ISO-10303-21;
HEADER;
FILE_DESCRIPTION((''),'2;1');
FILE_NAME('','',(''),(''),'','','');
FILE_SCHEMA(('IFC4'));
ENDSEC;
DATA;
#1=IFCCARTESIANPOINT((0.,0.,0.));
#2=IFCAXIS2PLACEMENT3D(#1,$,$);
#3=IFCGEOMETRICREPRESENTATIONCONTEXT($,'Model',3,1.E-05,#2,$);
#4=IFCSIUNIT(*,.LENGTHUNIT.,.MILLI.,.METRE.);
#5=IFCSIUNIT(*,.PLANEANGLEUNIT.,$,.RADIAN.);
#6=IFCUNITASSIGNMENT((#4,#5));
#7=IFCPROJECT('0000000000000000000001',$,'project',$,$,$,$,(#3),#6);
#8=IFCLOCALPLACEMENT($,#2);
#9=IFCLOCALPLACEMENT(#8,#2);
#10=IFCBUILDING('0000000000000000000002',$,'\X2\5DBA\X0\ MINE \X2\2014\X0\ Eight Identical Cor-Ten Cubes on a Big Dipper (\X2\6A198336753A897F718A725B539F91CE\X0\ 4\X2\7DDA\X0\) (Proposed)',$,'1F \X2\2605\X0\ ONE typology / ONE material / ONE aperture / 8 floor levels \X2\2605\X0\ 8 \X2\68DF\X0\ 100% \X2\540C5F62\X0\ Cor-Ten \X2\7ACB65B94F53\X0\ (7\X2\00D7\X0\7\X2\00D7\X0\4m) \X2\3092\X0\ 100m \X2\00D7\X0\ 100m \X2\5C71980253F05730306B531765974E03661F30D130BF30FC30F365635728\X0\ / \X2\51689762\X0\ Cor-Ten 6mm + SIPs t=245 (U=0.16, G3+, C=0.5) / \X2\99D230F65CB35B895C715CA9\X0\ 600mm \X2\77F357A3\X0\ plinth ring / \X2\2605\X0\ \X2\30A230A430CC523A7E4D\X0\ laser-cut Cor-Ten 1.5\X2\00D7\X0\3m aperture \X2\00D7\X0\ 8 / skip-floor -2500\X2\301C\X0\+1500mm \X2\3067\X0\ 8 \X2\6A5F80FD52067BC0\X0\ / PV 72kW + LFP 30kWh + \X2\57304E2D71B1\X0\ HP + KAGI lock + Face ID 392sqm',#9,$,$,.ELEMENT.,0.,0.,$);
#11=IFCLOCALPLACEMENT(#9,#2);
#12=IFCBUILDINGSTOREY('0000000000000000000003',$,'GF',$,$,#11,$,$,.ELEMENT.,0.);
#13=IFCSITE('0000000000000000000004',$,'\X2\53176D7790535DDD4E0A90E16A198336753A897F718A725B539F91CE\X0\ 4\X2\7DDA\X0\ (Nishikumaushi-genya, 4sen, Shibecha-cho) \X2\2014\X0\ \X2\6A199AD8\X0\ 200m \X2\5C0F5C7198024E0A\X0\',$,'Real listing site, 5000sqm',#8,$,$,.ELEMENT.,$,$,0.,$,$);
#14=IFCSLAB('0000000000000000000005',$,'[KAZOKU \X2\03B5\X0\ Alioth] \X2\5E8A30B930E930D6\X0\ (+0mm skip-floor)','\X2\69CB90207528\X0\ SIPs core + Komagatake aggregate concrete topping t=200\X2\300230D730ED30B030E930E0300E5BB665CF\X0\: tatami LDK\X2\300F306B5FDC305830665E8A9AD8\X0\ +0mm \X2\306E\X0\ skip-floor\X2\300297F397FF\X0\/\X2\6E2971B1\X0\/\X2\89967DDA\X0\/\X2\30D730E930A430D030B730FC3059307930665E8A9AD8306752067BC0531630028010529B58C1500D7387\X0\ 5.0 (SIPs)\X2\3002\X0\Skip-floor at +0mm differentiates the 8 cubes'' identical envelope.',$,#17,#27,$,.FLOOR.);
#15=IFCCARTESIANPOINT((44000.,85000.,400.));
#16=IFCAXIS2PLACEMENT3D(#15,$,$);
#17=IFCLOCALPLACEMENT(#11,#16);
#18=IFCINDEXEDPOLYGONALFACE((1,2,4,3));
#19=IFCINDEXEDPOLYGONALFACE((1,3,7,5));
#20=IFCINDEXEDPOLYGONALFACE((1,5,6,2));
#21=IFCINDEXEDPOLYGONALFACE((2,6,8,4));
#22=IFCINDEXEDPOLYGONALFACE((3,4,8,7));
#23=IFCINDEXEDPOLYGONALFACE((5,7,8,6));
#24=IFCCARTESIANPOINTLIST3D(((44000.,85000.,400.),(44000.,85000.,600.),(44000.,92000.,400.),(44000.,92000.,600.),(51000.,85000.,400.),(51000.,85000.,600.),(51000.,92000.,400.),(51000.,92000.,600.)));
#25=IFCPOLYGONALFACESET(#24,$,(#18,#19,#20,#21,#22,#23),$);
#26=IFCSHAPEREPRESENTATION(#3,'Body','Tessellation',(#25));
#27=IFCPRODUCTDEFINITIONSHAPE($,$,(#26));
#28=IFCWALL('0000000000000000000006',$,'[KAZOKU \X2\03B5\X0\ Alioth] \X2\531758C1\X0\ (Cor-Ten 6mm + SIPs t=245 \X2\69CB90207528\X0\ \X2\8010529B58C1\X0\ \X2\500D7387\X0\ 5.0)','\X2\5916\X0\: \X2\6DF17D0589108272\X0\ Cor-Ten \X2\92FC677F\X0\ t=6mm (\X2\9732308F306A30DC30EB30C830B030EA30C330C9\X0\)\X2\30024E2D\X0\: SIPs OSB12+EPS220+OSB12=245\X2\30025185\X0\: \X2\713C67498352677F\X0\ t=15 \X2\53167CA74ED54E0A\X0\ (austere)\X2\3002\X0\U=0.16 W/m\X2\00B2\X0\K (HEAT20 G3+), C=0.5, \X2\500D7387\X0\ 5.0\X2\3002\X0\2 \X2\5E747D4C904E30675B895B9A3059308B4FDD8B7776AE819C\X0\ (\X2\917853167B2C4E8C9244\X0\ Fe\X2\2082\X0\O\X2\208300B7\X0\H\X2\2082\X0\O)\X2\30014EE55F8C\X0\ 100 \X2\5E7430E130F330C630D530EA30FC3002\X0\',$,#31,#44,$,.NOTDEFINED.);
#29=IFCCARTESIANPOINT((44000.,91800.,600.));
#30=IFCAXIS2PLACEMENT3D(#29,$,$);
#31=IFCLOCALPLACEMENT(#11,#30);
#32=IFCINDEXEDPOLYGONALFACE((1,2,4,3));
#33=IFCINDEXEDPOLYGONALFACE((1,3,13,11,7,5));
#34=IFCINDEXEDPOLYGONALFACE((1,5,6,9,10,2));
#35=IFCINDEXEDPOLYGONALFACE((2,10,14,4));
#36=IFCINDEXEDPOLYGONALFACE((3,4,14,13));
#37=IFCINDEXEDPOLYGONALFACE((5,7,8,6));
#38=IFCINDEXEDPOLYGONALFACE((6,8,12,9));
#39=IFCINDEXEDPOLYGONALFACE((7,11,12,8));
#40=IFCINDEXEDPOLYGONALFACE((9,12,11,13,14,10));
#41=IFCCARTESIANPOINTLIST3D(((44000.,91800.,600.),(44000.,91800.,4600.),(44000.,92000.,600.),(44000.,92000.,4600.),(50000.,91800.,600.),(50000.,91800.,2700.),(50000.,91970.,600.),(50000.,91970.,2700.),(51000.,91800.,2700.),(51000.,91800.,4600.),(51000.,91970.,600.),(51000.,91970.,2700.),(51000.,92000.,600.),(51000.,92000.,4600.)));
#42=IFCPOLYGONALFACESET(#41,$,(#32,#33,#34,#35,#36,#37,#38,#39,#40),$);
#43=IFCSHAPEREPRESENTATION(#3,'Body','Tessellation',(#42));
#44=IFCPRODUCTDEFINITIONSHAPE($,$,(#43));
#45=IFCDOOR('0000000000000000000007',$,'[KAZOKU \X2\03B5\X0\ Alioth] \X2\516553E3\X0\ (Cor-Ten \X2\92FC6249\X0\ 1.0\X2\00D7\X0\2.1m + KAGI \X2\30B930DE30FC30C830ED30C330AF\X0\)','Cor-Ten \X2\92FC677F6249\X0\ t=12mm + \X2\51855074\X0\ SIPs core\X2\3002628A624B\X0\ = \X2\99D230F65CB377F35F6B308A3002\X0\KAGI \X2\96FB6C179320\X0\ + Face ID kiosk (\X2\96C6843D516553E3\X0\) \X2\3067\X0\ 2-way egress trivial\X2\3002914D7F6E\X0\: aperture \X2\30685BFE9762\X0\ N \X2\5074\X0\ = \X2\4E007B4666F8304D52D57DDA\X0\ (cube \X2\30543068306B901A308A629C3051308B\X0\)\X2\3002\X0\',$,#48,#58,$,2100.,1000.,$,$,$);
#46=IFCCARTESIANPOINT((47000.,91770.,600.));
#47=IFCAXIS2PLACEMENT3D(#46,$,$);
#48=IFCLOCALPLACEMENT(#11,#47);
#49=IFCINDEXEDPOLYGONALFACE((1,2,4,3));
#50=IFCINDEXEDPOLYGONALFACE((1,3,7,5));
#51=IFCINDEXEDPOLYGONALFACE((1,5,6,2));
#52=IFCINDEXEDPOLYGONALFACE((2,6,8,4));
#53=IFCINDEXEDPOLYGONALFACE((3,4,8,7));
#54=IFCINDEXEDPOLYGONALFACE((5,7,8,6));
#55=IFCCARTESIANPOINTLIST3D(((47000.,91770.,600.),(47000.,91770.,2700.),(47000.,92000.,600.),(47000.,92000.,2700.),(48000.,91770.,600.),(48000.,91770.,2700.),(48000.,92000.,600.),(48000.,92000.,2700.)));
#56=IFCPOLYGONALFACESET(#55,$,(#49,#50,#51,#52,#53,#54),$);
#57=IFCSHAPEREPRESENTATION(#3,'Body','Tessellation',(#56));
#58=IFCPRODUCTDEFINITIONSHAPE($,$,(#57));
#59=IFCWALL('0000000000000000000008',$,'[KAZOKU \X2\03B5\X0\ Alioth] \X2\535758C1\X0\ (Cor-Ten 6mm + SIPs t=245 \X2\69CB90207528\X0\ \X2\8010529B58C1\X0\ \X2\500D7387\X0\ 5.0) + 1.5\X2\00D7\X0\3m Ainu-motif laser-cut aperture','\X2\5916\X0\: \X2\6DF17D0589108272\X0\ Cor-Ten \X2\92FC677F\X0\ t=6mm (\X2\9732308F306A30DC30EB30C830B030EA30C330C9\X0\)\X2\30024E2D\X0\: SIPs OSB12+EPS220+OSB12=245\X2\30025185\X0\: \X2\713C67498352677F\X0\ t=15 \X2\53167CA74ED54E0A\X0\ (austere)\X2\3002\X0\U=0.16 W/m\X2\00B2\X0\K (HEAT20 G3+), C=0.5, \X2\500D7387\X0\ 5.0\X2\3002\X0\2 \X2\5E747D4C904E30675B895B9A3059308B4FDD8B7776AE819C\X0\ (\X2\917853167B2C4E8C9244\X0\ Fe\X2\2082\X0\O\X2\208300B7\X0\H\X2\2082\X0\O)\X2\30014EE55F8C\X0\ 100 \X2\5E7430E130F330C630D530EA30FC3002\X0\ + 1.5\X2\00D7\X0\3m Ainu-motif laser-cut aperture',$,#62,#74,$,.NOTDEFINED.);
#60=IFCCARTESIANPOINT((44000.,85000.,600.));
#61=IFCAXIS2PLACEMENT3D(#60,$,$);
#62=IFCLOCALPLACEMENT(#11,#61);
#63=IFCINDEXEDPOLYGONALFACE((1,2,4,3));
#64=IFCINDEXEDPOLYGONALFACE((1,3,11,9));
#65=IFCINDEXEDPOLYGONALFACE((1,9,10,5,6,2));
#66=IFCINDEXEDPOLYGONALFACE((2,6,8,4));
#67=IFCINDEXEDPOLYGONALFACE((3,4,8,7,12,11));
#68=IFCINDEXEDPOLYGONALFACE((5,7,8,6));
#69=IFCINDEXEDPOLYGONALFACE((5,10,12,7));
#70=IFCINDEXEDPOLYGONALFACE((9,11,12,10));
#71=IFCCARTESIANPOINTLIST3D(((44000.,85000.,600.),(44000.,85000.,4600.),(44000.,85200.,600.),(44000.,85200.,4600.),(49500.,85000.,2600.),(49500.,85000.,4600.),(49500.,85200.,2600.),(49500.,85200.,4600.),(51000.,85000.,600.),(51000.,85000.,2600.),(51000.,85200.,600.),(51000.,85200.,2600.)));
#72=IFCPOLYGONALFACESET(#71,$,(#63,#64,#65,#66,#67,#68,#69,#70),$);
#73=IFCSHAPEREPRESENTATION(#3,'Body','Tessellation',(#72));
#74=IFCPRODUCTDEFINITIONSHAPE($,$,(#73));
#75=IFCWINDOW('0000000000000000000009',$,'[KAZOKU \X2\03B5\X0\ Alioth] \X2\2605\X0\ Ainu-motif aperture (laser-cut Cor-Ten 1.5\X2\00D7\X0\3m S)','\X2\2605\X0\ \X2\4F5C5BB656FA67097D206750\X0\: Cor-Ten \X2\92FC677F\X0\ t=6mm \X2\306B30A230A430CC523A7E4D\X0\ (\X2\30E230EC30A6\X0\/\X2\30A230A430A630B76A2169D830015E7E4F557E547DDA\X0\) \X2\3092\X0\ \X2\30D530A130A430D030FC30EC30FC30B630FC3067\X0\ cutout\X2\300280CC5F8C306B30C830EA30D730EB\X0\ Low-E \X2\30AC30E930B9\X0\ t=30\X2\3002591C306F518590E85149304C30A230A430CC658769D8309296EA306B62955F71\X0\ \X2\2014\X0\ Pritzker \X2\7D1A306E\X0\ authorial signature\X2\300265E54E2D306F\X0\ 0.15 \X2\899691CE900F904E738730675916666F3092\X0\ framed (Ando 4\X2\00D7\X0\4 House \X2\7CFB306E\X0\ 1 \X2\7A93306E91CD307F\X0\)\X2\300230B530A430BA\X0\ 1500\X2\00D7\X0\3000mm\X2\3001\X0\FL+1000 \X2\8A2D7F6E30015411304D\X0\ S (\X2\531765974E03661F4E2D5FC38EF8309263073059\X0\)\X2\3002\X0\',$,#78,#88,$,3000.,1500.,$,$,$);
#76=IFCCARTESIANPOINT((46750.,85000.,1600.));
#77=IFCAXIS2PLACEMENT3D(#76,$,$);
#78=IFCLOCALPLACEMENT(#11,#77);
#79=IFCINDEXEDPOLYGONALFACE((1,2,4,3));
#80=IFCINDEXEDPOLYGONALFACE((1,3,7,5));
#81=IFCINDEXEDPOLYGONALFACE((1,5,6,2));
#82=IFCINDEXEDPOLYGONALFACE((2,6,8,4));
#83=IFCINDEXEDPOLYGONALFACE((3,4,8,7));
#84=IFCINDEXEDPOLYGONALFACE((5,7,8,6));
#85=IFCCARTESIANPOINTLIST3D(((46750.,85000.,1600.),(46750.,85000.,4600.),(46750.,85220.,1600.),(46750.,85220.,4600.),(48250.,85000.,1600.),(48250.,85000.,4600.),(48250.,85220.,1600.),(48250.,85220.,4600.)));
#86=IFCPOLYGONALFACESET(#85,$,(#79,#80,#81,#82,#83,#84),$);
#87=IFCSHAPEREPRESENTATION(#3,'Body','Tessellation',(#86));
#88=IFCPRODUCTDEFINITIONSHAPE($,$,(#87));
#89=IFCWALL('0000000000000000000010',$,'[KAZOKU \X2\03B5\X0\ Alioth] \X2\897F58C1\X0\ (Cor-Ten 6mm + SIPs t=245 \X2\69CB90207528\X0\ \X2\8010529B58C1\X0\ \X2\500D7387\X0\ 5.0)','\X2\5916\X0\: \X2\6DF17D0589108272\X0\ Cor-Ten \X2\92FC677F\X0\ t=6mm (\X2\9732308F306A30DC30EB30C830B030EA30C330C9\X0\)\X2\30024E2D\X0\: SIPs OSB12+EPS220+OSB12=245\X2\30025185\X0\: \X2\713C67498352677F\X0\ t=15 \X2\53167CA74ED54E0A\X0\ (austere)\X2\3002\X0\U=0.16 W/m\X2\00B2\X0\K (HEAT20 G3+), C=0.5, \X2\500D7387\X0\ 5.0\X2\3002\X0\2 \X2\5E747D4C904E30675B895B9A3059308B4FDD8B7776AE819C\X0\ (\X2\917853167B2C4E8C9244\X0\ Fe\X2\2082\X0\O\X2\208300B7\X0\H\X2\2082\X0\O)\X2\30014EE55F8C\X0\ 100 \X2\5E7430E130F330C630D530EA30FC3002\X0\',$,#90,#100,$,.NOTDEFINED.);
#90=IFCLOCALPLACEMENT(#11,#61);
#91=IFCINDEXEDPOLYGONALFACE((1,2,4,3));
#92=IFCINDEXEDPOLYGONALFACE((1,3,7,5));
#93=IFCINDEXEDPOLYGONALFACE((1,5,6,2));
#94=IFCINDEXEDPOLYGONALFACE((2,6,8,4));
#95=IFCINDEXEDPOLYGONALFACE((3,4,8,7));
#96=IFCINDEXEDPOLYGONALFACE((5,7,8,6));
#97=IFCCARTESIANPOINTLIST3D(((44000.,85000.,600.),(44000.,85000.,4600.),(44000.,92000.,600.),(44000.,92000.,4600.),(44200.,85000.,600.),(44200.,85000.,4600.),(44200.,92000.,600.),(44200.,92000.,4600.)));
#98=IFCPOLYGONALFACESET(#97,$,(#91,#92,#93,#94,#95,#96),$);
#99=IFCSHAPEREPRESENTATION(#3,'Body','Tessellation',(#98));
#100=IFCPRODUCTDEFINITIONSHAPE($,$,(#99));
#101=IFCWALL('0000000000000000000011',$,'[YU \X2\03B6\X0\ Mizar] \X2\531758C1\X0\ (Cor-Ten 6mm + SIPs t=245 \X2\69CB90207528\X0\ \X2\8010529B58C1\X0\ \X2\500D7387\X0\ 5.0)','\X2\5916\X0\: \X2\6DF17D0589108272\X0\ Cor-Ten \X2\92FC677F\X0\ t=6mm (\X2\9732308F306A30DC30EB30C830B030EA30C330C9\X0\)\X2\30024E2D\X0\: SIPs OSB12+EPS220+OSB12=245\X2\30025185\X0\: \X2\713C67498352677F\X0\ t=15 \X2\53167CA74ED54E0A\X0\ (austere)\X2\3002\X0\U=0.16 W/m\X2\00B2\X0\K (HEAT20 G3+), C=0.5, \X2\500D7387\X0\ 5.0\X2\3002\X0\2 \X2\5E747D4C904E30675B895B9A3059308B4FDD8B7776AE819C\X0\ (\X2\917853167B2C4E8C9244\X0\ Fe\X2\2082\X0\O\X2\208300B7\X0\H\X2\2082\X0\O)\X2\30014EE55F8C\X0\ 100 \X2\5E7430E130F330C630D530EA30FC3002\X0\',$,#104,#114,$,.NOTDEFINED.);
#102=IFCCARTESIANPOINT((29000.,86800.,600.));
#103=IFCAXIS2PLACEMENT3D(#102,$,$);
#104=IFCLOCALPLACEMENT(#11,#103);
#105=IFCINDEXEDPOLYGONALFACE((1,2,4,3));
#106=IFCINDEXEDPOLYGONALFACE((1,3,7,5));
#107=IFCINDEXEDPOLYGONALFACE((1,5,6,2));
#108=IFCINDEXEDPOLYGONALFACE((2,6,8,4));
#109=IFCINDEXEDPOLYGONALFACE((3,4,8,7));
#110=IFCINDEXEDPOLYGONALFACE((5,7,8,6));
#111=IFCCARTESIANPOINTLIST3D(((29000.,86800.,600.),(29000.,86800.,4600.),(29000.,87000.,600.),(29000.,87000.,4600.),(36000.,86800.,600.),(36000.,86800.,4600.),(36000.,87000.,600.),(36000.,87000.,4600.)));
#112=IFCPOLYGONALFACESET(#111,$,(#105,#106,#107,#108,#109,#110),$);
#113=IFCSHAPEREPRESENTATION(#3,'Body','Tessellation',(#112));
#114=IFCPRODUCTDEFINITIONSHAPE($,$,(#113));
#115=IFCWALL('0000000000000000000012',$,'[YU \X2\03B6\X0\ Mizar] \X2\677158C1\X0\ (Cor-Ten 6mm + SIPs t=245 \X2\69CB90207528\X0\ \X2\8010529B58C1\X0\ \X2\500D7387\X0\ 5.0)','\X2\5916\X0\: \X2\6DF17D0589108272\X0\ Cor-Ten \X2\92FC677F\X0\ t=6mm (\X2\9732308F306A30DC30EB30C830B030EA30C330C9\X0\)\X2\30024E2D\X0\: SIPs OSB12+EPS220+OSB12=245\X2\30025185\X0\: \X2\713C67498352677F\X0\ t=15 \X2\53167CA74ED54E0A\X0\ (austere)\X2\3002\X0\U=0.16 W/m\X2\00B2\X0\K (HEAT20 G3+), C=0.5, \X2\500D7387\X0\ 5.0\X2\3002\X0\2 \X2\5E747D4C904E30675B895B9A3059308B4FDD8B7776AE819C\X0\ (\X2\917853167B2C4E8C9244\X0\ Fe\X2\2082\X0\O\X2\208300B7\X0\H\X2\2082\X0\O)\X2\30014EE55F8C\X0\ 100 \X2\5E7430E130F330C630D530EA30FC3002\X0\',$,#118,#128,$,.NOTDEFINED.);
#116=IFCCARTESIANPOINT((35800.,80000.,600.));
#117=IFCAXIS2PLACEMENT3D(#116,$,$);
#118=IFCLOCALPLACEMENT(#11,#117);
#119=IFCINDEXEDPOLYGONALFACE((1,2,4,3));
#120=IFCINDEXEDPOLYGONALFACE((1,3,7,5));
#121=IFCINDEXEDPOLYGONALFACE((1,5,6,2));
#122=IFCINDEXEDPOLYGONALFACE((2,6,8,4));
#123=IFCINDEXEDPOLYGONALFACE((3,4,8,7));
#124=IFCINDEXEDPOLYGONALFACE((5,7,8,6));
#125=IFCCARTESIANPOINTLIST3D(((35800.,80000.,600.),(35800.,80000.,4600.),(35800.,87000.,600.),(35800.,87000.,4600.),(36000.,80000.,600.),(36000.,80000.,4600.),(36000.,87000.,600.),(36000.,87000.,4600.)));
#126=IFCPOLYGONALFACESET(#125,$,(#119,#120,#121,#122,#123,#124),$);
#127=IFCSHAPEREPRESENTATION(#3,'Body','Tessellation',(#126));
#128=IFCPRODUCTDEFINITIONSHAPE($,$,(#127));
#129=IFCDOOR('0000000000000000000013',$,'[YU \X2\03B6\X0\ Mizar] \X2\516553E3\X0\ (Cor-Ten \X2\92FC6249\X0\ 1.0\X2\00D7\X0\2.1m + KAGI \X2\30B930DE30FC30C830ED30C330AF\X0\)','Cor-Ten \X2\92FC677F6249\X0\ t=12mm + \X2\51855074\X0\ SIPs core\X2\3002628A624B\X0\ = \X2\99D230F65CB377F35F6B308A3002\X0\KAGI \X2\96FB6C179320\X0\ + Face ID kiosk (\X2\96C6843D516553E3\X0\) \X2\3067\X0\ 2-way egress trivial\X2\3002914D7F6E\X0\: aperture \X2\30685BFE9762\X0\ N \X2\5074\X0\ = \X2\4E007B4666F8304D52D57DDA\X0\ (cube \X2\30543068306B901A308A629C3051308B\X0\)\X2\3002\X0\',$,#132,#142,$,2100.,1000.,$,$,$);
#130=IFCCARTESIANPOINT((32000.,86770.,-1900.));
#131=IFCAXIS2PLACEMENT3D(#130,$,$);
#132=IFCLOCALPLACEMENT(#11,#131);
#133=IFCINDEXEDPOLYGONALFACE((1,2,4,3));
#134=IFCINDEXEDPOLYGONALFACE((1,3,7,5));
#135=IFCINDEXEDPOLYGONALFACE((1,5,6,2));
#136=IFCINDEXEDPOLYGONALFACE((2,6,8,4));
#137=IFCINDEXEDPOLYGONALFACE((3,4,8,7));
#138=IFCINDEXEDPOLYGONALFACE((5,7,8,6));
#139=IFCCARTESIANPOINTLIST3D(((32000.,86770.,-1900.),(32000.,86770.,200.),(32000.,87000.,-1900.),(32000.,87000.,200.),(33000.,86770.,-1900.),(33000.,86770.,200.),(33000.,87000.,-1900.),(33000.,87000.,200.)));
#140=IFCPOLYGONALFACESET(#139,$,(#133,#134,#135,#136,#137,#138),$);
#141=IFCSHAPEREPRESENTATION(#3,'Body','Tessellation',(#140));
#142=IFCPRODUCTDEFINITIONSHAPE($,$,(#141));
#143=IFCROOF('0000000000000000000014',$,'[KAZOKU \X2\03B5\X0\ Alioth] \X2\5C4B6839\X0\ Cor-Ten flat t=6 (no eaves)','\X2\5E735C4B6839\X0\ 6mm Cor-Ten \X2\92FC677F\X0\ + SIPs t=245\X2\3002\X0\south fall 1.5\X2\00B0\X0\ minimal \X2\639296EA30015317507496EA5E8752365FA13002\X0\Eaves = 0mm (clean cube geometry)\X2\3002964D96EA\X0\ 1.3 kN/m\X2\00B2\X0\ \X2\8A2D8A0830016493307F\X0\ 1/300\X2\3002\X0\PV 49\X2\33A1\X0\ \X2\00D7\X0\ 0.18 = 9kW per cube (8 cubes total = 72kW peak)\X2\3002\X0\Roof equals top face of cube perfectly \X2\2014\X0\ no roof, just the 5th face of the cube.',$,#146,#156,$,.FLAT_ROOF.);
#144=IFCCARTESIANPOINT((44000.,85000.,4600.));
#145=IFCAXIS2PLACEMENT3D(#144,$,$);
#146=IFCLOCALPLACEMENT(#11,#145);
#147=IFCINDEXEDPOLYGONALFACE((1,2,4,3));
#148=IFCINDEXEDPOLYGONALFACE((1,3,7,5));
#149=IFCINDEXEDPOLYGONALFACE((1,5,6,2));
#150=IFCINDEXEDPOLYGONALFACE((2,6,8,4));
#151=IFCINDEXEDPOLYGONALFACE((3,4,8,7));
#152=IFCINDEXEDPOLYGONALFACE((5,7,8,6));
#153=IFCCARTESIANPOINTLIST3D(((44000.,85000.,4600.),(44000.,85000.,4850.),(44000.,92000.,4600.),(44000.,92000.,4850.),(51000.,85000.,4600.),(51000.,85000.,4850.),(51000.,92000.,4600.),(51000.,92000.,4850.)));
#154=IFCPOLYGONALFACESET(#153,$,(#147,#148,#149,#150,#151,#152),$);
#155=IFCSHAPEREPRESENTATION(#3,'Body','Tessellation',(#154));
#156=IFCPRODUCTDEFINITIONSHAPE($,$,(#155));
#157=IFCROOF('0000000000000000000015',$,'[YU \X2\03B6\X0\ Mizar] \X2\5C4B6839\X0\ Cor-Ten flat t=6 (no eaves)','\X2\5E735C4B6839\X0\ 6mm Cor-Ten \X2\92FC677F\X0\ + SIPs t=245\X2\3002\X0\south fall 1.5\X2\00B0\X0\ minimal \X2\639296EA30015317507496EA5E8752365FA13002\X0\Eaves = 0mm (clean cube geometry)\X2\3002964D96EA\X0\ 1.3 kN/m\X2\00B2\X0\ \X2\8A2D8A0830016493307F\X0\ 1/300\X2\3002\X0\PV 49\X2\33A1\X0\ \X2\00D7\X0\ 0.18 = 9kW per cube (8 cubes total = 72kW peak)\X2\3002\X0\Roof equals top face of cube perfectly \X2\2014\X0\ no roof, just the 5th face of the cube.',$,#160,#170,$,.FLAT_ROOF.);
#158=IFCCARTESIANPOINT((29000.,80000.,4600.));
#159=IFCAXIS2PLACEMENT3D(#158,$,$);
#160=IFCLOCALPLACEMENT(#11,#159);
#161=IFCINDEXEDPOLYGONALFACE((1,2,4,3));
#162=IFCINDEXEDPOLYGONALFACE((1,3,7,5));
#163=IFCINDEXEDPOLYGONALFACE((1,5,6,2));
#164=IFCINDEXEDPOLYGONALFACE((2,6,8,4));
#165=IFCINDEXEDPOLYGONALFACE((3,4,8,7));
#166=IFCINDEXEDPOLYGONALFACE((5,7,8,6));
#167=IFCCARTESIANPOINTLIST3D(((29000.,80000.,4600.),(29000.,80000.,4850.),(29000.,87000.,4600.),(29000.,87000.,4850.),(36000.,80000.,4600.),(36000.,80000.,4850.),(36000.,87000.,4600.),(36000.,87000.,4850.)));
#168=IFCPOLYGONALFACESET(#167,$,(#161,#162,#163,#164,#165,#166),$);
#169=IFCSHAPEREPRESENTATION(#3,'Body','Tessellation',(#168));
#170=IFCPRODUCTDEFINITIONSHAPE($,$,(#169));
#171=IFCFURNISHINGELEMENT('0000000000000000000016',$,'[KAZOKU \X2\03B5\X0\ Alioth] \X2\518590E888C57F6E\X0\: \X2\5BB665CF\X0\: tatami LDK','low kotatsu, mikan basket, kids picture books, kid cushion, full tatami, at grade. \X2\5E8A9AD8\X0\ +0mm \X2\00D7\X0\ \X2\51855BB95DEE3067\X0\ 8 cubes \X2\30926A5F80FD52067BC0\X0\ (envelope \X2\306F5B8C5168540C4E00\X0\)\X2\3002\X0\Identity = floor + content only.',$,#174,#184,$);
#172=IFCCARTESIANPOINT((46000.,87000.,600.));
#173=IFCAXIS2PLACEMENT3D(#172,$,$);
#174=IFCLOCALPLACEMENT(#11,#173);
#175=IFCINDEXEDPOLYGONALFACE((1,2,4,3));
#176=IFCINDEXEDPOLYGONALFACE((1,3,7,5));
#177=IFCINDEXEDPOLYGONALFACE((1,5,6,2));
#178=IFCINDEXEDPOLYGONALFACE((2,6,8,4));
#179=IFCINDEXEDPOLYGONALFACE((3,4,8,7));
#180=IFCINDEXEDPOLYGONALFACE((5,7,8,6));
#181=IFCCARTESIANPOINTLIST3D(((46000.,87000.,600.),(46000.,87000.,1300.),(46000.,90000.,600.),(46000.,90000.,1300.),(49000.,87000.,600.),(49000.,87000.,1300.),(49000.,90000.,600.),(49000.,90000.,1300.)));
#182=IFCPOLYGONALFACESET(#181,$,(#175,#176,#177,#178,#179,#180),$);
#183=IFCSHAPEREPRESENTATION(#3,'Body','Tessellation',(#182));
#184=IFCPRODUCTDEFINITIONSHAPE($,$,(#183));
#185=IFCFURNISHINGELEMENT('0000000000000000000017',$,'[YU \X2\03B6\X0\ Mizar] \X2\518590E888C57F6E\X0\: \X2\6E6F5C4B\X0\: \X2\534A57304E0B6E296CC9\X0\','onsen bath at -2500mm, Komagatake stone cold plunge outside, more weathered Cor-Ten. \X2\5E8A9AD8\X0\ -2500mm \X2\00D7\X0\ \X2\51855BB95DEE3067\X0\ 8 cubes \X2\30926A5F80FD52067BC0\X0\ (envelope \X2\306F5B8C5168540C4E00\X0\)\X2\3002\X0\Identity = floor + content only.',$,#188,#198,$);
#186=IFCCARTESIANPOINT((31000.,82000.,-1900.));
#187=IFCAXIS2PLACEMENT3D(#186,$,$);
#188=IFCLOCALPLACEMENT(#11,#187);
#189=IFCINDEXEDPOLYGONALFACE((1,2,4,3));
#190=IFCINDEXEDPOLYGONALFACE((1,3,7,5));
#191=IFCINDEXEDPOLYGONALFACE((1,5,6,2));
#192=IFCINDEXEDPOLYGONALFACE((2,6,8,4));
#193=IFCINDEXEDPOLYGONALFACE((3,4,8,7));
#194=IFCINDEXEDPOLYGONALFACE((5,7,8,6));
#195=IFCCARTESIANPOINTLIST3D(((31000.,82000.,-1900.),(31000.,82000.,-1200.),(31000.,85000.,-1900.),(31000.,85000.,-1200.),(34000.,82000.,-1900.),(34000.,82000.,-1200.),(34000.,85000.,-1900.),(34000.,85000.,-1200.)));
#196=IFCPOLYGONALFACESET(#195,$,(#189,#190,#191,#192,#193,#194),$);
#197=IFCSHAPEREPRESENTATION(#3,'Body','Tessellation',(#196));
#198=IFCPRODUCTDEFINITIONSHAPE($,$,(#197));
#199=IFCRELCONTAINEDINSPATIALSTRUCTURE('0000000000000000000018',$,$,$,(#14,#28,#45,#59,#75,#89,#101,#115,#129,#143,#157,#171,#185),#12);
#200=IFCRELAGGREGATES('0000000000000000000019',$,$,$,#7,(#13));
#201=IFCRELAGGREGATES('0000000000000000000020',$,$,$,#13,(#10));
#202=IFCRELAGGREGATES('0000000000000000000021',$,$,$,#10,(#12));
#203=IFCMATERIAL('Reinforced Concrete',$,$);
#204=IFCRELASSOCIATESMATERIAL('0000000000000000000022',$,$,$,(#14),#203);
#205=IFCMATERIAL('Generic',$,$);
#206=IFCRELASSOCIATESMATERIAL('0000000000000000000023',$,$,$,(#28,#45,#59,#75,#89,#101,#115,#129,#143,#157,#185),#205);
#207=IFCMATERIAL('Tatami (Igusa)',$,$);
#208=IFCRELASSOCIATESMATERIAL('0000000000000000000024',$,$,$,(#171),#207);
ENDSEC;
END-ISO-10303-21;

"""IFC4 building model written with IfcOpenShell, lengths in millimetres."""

from ifc_helpers import new_model, si_unit, frame, frame_2d, origin, place, context, project, spatial, rectangle, extrude, material, element, fill, save


model = new_model("IFC4")

# Units and contexts
model_context = context("Model", 3, precision=1e-05, world=origin())
ifc_project = project(units=[si_unit("LENGTHUNIT", "METRE", prefix="MILLI"), si_unit("PLANEANGLEUNIT", "RADIAN")], contexts=[model_context])

# Site, building, storey
site_placement = place(None, origin())
site = spatial("IfcSite", under=ifc_project, at=site_placement, Name="北海道川上郡標茶町西熊牛原野 4線 (Nishikumaushi-genya, 4sen, Shibecha-cho) — 標高 200m 小山頂上", ObjectType="Real listing site, 5000sqm", CompositionType="ELEMENT", RefElevation=0.0)
building_placement = place(site_placement, origin())
building = spatial("IfcBuilding", under=site, at=building_placement, Name="嶺 MINE — Eight Identical Cor-Ten Cubes on a Big Dipper (標茶町西熊牛原野 4線) (Proposed)", ObjectType="1F ★ ONE typology / ONE material / ONE aperture / 8 floor levels ★ 8 棟 100% 同形 Cor-Ten 立方体 (7×7×4m) を 100m × 100m 山頂台地に北斗七星パターン散在 / 全面 Cor-Ten 6mm + SIPs t=245 (U=0.16, G3+, C=0.5) / 駒ヶ岳安山岩 600mm 石垣 plinth ring / ★ アイヌ刺繍 laser-cut Cor-Ten 1.5×3m aperture × 8 / skip-floor -2500〜+1500mm で 8 機能分節 / PV 72kW + LFP 30kWh + 地中熱 HP + KAGI lock + Face ID 392sqm", CompositionType="ELEMENT", ElevationOfRefHeight=0.0, ElevationOfTerrain=0.0)
storey_placement = place(building_placement, origin())
storey = spatial("IfcBuildingStorey", under=building, at=storey_placement, Name="GF", CompositionType="ELEMENT", Elevation=0.0)

# Slab
ifc_material_1 = material(Name="Reinforced Concrete")
slab_placement = place(storey_placement, frame((44000.0, 85000.0, 400.0)))
element("IfcSlab", 1, at=slab_placement, inside=storey, material=ifc_material_1, Name="[KAZOKU ε Alioth] 床スラブ (+0mm skip-floor)", Description="構造用 SIPs core + Komagatake aggregate concrete topping t=200。プログラム『家族: tatami LDK』に応じて床高 +0mm の skip-floor。音響/温熱/視線/プライバシーすべて床高で分節化。耐力壁倍率 5.0 (SIPs)。Skip-floor at +0mm differentiates the 8 cubes' identical envelope.", PredefinedType="FLOOR", context=model_context, shape_type="SweptSolid", body=[
    extrude(rectangle(XDim=7000.0, YDim=7000.0, at=frame_2d((3500.0, 3500.0))), frame((44000.0, 85000.0, 400.0)), (0.0, 0.0, 1.0), 200.0),
])

# Wall, opening, door
ifc_material_2 = material(Name="Generic")
wall_1_placement = place(storey_placement, frame((44000.0, 91800.0, 600.0)))
wall_1 = element("IfcWall", 2, at=wall_1_placement, inside=storey, material=ifc_material_2, Name="[KAZOKU ε Alioth] 北壁 (Cor-Ten 6mm + SIPs t=245 構造用 耐力壁 倍率 5.0)", Description="外: 深紅褐色 Cor-Ten 鋼板 t=6mm (露わなボルトグリッド)。中: SIPs OSB12+EPS220+OSB12=245。内: 焼杉荒板 t=15 化粧仕上 (austere)。U=0.16 W/m²K (HEAT20 G3+), C=0.5, 倍率 5.0。2 年経過で安定する保護皮膜 (酸化第二鉄 Fe₂O₃·H₂O)、以後 100 年メンテフリー。", PredefinedType="NOTDEFINED", context=model_context, shape_type="SweptSolid", body=[
    extrude(rectangle(XDim=7000.0, YDim=200.0, at=frame_2d((3500.0, 100.0))), frame((44000.0, 91800.0, 600.0)), (0.0, 0.0, 1.0), 4000.0),
])
opening_1_placement = place(storey_placement, frame((47000.0, 91770.0, 600.0)))
opening_1 = element("IfcOpeningElement", 3, at=opening_1_placement, cuts=wall_1, PredefinedType="NOTDEFINED", context=model_context, shape_type="SweptSolid", body=[
    extrude(rectangle(XDim=1000.0, YDim=230.0, at=frame_2d((500.0, 115.0))), frame((47000.0, 91770.0, 600.0)), (0.0, 0.0, 1.0), 2100.0),
])
door_1_placement = place(storey_placement, frame((47000.0, 91770.0, 600.0)))
door_1 = element("IfcDoor", 4, at=door_1_placement, inside=storey, material=ifc_material_2, Name="[KAZOKU ε Alioth] 入口 (Cor-Ten 鋼扉 1.0×2.1m + KAGI スマートロック)", Description="Cor-Ten 鋼板扉 t=12mm + 内側 SIPs core。把手 = 駒ヶ岳石彫り。KAGI 電気錠 + Face ID kiosk (集落入口) で 2-way egress trivial。配置: aperture と対面 N 側 = 一筆書き動線 (cube ごとに通り抜ける)。", OverallHeight=2100.0, OverallWidth=1000.0, context=model_context, shape_type="SweptSolid", body=[
    extrude(rectangle(XDim=1000.0, YDim=230.0, at=frame_2d((500.0, 115.0))), frame((47000.0, 91770.0, 600.0)), (0.0, 0.0, 1.0), 2100.0),
])
fill(opening_1, door_1)

# Wall, opening, window
wall_2_placement = place(storey_placement, frame((44000.0, 85000.0, 600.0)))
wall_2 = element("IfcWall", 5, at=wall_2_placement, inside=storey, material=ifc_material_2, Name="[KAZOKU ε Alioth] 南壁 (Cor-Ten 6mm + SIPs t=245 構造用 耐力壁 倍率 5.0) + 1.5×3m Ainu-motif laser-cut aperture", Description="外: 深紅褐色 Cor-Ten 鋼板 t=6mm (露わなボルトグリッド)。中: SIPs OSB12+EPS220+OSB12=245。内: 焼杉荒板 t=15 化粧仕上 (austere)。U=0.16 W/m²K (HEAT20 G3+), C=0.5, 倍率 5.0。2 年経過で安定する保護皮膜 (酸化第二鉄 Fe₂O₃·H₂O)、以後 100 年メンテフリー。 + 1.5×3m Ainu-motif laser-cut aperture", PredefinedType="NOTDEFINED", context=model_context, shape_type="SweptSolid", body=[
    extrude(rectangle(XDim=7000.0, YDim=200.0, at=frame_2d((3500.0, 100.0))), frame((44000.0, 85000.0, 600.0)), (0.0, 0.0, 1.0), 4000.0),
])
opening_2_placement = place(storey_placement, frame((46750.0, 85000.0, 1600.0)))
opening_2 = element("IfcOpeningElement", 6, at=opening_2_placement, cuts=wall_2, PredefinedType="NOTDEFINED", context=model_context, shape_type="SweptSolid", body=[
    extrude(rectangle(XDim=1500.0, YDim=220.0, at=frame_2d((750.0, 110.0))), frame((46750.0, 85000.0, 1600.0)), (0.0, 0.0, 1.0), 3000.0),
])
window_placement = place(storey_placement, frame((46750.0, 85000.0, 1600.0)))
window = element("IfcWindow", 7, at=window_placement, inside=storey, material=ifc_material_2, Name="[KAZOKU ε Alioth] ★ Ainu-motif aperture (laser-cut Cor-Ten 1.5×3m S)", Description="★ 作家固有素材: Cor-Ten 鋼板 t=6mm にアイヌ刺繍 (モレウ/アイウシ模様、幾何織線) を ファイバーレーザーで cutout。背後にトリプル Low-E ガラス t=30。夜は内部光がアイヌ文様を雪に投影 — Pritzker 級の authorial signature。日中は 0.15 視野透過率で外景を framed (Ando 4×4 House 系の 1 窓の重み)。サイズ 1500×3000mm、FL+1000 設置、向き S (北斗七星中心軸を指す)。", OverallHeight=3000.0, OverallWidth=1500.0, context=model_context, shape_type="SweptSolid", body=[
    extrude(rectangle(XDim=1500.0, YDim=220.0, at=frame_2d((750.0, 110.0))), frame((46750.0, 85000.0, 1600.0)), (0.0, 0.0, 1.0), 3000.0),
])
fill(opening_2, window)

# Walls
wall_3_placement = place(storey_placement, frame((44000.0, 85000.0, 600.0)))
element("IfcWall", 8, at=wall_3_placement, inside=storey, material=ifc_material_2, Name="[KAZOKU ε Alioth] 西壁 (Cor-Ten 6mm + SIPs t=245 構造用 耐力壁 倍率 5.0)", Description="外: 深紅褐色 Cor-Ten 鋼板 t=6mm (露わなボルトグリッド)。中: SIPs OSB12+EPS220+OSB12=245。内: 焼杉荒板 t=15 化粧仕上 (austere)。U=0.16 W/m²K (HEAT20 G3+), C=0.5, 倍率 5.0。2 年経過で安定する保護皮膜 (酸化第二鉄 Fe₂O₃·H₂O)、以後 100 年メンテフリー。", PredefinedType="NOTDEFINED", context=model_context, shape_type="SweptSolid", body=[
    extrude(rectangle(XDim=200.0, YDim=7000.0, at=frame_2d((100.0, 3500.0))), frame((44000.0, 85000.0, 600.0)), (0.0, 0.0, 1.0), 4000.0),
])
wall_4_placement = place(storey_placement, frame((29000.0, 86800.0, 600.0)))
element("IfcWall", 9, at=wall_4_placement, inside=storey, material=ifc_material_2, Name="[YU ζ Mizar] 北壁 (Cor-Ten 6mm + SIPs t=245 構造用 耐力壁 倍率 5.0)", Description="外: 深紅褐色 Cor-Ten 鋼板 t=6mm (露わなボルトグリッド)。中: SIPs OSB12+EPS220+OSB12=245。内: 焼杉荒板 t=15 化粧仕上 (austere)。U=0.16 W/m²K (HEAT20 G3+), C=0.5, 倍率 5.0。2 年経過で安定する保護皮膜 (酸化第二鉄 Fe₂O₃·H₂O)、以後 100 年メンテフリー。", PredefinedType="NOTDEFINED", context=model_context, shape_type="SweptSolid", body=[
    extrude(rectangle(XDim=7000.0, YDim=200.0, at=frame_2d((3500.0, 100.0))), frame((29000.0, 86800.0, 600.0)), (0.0, 0.0, 1.0), 4000.0),
])
wall_5_placement = place(storey_placement, frame((35800.0, 80000.0, 600.0)))
element("IfcWall", 10, at=wall_5_placement, inside=storey, material=ifc_material_2, Name="[YU ζ Mizar] 東壁 (Cor-Ten 6mm + SIPs t=245 構造用 耐力壁 倍率 5.0)", Description="外: 深紅褐色 Cor-Ten 鋼板 t=6mm (露わなボルトグリッド)。中: SIPs OSB12+EPS220+OSB12=245。内: 焼杉荒板 t=15 化粧仕上 (austere)。U=0.16 W/m²K (HEAT20 G3+), C=0.5, 倍率 5.0。2 年経過で安定する保護皮膜 (酸化第二鉄 Fe₂O₃·H₂O)、以後 100 年メンテフリー。", PredefinedType="NOTDEFINED", context=model_context, shape_type="SweptSolid", body=[
    extrude(rectangle(XDim=200.0, YDim=7000.0, at=frame_2d((100.0, 3500.0))), frame((35800.0, 80000.0, 600.0)), (0.0, 0.0, 1.0), 4000.0),
])

# Door
door_2_placement = place(storey_placement, frame((32000.0, 86770.0, -1900.0)))
element("IfcDoor", 11, at=door_2_placement, inside=storey, material=ifc_material_2, Name="[YU ζ Mizar] 入口 (Cor-Ten 鋼扉 1.0×2.1m + KAGI スマートロック)", Description="Cor-Ten 鋼板扉 t=12mm + 内側 SIPs core。把手 = 駒ヶ岳石彫り。KAGI 電気錠 + Face ID kiosk (集落入口) で 2-way egress trivial。配置: aperture と対面 N 側 = 一筆書き動線 (cube ごとに通り抜ける)。", OverallHeight=2100.0, OverallWidth=1000.0, context=model_context, shape_type="SweptSolid", body=[
    extrude(rectangle(XDim=1000.0, YDim=230.0, at=frame_2d((500.0, 115.0))), frame((32000.0, 86770.0, -1900.0)), (0.0, 0.0, 1.0), 2100.0),
])

# Roofs
roof_1_placement = place(storey_placement, frame((44000.0, 85000.0, 4600.0)))
element("IfcRoof", 12, at=roof_1_placement, inside=storey, material=ifc_material_2, Name="[KAZOKU ε Alioth] 屋根 Cor-Ten flat t=6 (no eaves)", Description="平屋根 6mm Cor-Ten 鋼板 + SIPs t=245。south fall 1.5° minimal 排雪、北側雪庇制御。Eaves = 0mm (clean cube geometry)。降雪 1.3 kN/m² 設計、撓み 1/300。PV 49㎡ × 0.18 = 9kW per cube (8 cubes total = 72kW peak)。Roof equals top face of cube perfectly — no roof, just the 5th face of the cube.", PredefinedType="FLAT_ROOF", context=model_context, shape_type="SweptSolid", body=[
    extrude(rectangle(XDim=7000.0, YDim=7000.0, at=frame_2d((3500.0, 3500.0))), frame((44000.0, 85000.0, 4600.0)), (0.0, 0.0, 1.0), 250.0),
])
roof_2_placement = place(storey_placement, frame((29000.0, 80000.0, 4600.0)))
element("IfcRoof", 13, at=roof_2_placement, inside=storey, material=ifc_material_2, Name="[YU ζ Mizar] 屋根 Cor-Ten flat t=6 (no eaves)", Description="平屋根 6mm Cor-Ten 鋼板 + SIPs t=245。south fall 1.5° minimal 排雪、北側雪庇制御。Eaves = 0mm (clean cube geometry)。降雪 1.3 kN/m² 設計、撓み 1/300。PV 49㎡ × 0.18 = 9kW per cube (8 cubes total = 72kW peak)。Roof equals top face of cube perfectly — no roof, just the 5th face of the cube.", PredefinedType="FLAT_ROOF", context=model_context, shape_type="SweptSolid", body=[
    extrude(rectangle(XDim=7000.0, YDim=7000.0, at=frame_2d((3500.0, 3500.0))), frame((29000.0, 80000.0, 4600.0)), (0.0, 0.0, 1.0), 250.0),
])

# Furnishing elements
ifc_material_3 = material(Name="Tatami (Igusa)")
furnishing_1_placement = place(storey_placement, frame((46000.0, 87000.0, 600.0)))
element("IfcFurnishingElement", 14, at=furnishing_1_placement, inside=storey, material=ifc_material_3, Name="[KAZOKU ε Alioth] 内部装置: 家族: tatami LDK", Description="low kotatsu, mikan basket, kids picture books, kid cushion, full tatami, at grade. 床高 +0mm × 内容差で 8 cubes を機能分節 (envelope は完全同一)。Identity = floor + content only.", context=model_context, shape_type="SweptSolid", body=[
    extrude(rectangle(XDim=3000.0, YDim=3000.0, at=frame_2d((1500.0, 1500.0))), frame((46000.0, 87000.0, 600.0)), (0.0, 0.0, 1.0), 700.0),
])
furnishing_2_placement = place(storey_placement, frame((31000.0, 82000.0, -1900.0)))
element("IfcFurnishingElement", 15, at=furnishing_2_placement, inside=storey, material=ifc_material_2, Name="[YU ζ Mizar] 内部装置: 湯屋: 半地下温泉", Description="onsen bath at -2500mm, Komagatake stone cold plunge outside, more weathered Cor-Ten. 床高 -2500mm × 内容差で 8 cubes を機能分節 (envelope は完全同一)。Identity = floor + content only.", context=model_context, shape_type="SweptSolid", body=[
    extrude(rectangle(XDim=3000.0, YDim=3000.0, at=frame_2d((1500.0, 1500.0))), frame((31000.0, 82000.0, -1900.0)), (0.0, 0.0, 1.0), 700.0),
])

save(model, "model.ifc")
